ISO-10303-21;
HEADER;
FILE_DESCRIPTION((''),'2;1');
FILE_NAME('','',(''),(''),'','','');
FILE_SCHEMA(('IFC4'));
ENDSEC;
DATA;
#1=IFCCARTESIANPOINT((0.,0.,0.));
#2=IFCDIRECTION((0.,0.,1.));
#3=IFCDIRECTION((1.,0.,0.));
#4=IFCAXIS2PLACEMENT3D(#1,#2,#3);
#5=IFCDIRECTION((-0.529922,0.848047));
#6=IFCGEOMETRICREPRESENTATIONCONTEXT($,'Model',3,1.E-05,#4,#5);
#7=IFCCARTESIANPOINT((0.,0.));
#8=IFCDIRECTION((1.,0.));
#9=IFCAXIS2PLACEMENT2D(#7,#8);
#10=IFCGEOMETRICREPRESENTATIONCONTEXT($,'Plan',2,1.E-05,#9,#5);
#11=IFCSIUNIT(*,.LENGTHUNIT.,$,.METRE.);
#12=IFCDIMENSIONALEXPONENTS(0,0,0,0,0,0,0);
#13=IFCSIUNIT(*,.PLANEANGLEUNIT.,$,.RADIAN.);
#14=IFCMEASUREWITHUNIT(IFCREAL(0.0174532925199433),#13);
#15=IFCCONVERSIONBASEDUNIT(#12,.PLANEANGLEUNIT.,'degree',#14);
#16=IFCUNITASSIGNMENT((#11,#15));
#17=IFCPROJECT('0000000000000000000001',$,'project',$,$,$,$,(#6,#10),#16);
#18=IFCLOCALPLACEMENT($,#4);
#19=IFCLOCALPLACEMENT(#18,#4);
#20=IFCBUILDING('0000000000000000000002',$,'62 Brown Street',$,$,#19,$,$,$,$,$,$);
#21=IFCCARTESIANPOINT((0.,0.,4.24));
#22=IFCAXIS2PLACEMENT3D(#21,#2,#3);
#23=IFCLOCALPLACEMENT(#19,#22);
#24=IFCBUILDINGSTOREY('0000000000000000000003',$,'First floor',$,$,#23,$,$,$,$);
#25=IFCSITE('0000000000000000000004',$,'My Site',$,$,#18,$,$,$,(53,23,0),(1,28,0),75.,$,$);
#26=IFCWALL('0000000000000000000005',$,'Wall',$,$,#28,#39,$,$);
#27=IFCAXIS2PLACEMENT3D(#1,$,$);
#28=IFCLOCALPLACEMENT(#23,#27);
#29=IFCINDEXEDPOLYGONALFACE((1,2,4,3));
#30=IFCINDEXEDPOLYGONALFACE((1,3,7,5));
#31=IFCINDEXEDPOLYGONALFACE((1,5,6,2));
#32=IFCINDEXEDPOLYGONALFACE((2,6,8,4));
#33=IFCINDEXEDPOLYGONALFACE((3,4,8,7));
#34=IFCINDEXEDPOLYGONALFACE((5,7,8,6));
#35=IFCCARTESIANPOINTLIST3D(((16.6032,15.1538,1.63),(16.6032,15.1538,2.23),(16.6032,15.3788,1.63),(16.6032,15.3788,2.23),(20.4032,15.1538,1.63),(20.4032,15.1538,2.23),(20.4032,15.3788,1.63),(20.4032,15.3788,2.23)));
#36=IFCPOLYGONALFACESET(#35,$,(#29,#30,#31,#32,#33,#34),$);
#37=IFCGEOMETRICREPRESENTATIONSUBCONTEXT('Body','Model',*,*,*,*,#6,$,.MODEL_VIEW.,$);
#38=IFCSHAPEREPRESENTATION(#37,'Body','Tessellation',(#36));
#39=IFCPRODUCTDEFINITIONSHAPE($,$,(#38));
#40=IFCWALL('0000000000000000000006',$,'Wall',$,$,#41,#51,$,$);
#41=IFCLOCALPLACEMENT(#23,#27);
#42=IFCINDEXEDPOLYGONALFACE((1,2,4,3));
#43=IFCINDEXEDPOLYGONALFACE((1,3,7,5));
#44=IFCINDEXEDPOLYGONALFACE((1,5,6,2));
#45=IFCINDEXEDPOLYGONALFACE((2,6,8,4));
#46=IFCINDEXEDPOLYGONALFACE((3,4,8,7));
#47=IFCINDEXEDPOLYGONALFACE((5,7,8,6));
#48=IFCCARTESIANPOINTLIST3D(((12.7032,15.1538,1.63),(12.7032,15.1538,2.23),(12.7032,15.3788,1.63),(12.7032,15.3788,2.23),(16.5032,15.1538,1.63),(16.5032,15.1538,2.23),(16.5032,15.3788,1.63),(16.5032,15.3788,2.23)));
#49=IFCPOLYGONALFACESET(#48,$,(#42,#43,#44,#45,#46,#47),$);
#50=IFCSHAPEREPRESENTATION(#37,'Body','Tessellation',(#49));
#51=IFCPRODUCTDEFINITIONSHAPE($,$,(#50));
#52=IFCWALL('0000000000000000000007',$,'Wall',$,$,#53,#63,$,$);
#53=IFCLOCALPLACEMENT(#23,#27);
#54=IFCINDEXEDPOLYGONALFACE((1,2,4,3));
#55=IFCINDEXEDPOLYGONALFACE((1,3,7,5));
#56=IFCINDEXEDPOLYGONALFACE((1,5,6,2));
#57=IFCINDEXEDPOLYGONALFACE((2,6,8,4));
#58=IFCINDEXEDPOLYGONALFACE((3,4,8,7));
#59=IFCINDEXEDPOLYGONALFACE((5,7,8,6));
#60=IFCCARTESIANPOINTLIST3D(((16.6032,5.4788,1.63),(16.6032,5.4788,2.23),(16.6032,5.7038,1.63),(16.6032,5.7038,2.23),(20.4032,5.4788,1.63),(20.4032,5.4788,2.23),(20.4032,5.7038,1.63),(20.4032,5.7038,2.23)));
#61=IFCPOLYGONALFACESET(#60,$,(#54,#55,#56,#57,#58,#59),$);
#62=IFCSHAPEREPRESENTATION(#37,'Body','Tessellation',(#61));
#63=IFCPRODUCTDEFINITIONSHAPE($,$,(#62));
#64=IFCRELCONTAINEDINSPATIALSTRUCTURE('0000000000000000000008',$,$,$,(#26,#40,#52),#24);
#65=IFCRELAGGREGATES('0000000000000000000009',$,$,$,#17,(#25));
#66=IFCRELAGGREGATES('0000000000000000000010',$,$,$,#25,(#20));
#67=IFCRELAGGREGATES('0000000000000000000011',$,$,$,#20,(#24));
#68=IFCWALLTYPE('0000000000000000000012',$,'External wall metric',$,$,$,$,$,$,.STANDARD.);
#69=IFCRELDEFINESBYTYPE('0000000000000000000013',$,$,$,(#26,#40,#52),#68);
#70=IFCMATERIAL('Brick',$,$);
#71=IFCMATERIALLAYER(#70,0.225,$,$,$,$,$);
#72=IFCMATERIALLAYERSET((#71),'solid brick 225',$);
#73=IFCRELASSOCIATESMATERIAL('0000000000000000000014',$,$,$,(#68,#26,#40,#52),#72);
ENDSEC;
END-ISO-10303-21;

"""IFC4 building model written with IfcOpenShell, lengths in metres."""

from ifc_helpers import new_model, entity, si_unit, converted_unit, direction, frame, origin_with_axes, origin_2d_with_axis, place, context, subcontext, project, spatial, indexed_curve, outline, extrude, material, layer, layer_set, layer_usage, type_object, element, save


model = new_model("IFC4")

# Units and contexts
model_context = context("Model", 3, precision=1e-05, world=origin_with_axes(), true_north=direction((-0.529922, 0.848047)))
plan_context = context("Plan", 2, precision=1e-05, world=origin_2d_with_axis(), true_north=direction((-0.529922, 0.848047)))
body_context = subcontext(model_context, "Body", "Model", "MODEL_VIEW")
ifc_project = project(units=[si_unit("LENGTHUNIT", "METRE"), converted_unit("PLANEANGLEUNIT", "degree", entity("IfcReal", 0.0174532925199433), si_unit("PLANEANGLEUNIT", "RADIAN"), dimensions=[0, 0, 0, 0, 0, 0, 0])], contexts=[model_context, plan_context])

# Site, building, storey
site_placement = place(None, origin_with_axes())
site = spatial("IfcSite", under=ifc_project, at=site_placement, Name="My Site", RefLatitude=(53, 23, 0), RefLongitude=(1, 28, 0), RefElevation=75.0)
building_placement = place(site_placement, origin_with_axes())
building = spatial("IfcBuilding", under=site, at=building_placement, Name="62 Brown Street")
storey_placement = place(building_placement, frame((0.0, 0.0, 4.24), z_axis=(0.0, 0.0, 1.0), x_axis=(1.0, 0.0, 0.0)))
storey = spatial("IfcBuildingStorey", under=building, at=storey_placement, Name="First floor")

# Walls
ifc_material_1 = material(Name="Brick")
ifc_layer_1 = layer(ifc_material_1, 0.225)
ifc_layer_set_1 = layer_set([ifc_layer_1], Name="solid brick 225")
ifc_layer_usage_1 = layer_usage(ifc_layer_set_1, "AXIS2", "POSITIVE", 0.0)
wall_type = type_object("IfcWallType", Name="External wall metric", PredefinedType="STANDARD", material=ifc_layer_set_1)
wall_1_placement = place(storey_placement, frame((20.4032, 15.3788, 1.63), z_axis=(0.0, 0.0, 1.0), x_axis=(-1.0, 0.0, 0.0)))
element("IfcWall", 1, at=wall_1_placement, inside=storey, type_object=wall_type, material=ifc_layer_usage_1, Name="Wall", context=body_context, shape_type="SweptSolid", body=[
    extrude(outline(indexed_curve([(0.0, 0.0), (0.0, 0.225), (3.8, 0.225), (3.8, 0.0), (0.0, 0.0)], self_intersect=False)), origin_with_axes(), (0.0, 0.0, 1.0), 0.6),
])
ifc_layer_usage_2 = layer_usage(ifc_layer_set_1, "AXIS2", "POSITIVE", 0.0)
wall_2_placement = place(storey_placement, frame((16.5032, 15.3788, 1.63), z_axis=(0.0, 0.0, 1.0), x_axis=(-1.0, 0.0, 0.0)))
element("IfcWall", 2, at=wall_2_placement, inside=storey, type_object=wall_type, material=ifc_layer_usage_2, Name="Wall", context=body_context, shape_type="SweptSolid", body=[
    extrude(outline(indexed_curve([(0.0, 0.0), (0.0, 0.225), (3.8, 0.225), (3.8, 0.0), (0.0, 0.0)], self_intersect=False)), origin_with_axes(), (0.0, 0.0, 1.0), 0.6),
])
ifc_layer_usage_3 = layer_usage(ifc_layer_set_1, "AXIS2", "POSITIVE", 0.0)
wall_3_placement = place(storey_placement, frame((16.6032, 5.4788, 1.63), z_axis=(0.0, 0.0, 1.0), x_axis=(1.0, 0.0, 0.0)))
element("IfcWall", 3, at=wall_3_placement, inside=storey, type_object=wall_type, material=ifc_layer_usage_3, Name="Wall", context=body_context, shape_type="SweptSolid", body=[
    extrude(outline(indexed_curve([(0.0, 0.0), (0.0, 0.225), (3.8, 0.225), (3.8, 0.0), (0.0, 0.0)], self_intersect=False)), origin_with_axes(), (0.0, 0.0, 1.0), 0.6),
])

save(model, "model.ifc")
